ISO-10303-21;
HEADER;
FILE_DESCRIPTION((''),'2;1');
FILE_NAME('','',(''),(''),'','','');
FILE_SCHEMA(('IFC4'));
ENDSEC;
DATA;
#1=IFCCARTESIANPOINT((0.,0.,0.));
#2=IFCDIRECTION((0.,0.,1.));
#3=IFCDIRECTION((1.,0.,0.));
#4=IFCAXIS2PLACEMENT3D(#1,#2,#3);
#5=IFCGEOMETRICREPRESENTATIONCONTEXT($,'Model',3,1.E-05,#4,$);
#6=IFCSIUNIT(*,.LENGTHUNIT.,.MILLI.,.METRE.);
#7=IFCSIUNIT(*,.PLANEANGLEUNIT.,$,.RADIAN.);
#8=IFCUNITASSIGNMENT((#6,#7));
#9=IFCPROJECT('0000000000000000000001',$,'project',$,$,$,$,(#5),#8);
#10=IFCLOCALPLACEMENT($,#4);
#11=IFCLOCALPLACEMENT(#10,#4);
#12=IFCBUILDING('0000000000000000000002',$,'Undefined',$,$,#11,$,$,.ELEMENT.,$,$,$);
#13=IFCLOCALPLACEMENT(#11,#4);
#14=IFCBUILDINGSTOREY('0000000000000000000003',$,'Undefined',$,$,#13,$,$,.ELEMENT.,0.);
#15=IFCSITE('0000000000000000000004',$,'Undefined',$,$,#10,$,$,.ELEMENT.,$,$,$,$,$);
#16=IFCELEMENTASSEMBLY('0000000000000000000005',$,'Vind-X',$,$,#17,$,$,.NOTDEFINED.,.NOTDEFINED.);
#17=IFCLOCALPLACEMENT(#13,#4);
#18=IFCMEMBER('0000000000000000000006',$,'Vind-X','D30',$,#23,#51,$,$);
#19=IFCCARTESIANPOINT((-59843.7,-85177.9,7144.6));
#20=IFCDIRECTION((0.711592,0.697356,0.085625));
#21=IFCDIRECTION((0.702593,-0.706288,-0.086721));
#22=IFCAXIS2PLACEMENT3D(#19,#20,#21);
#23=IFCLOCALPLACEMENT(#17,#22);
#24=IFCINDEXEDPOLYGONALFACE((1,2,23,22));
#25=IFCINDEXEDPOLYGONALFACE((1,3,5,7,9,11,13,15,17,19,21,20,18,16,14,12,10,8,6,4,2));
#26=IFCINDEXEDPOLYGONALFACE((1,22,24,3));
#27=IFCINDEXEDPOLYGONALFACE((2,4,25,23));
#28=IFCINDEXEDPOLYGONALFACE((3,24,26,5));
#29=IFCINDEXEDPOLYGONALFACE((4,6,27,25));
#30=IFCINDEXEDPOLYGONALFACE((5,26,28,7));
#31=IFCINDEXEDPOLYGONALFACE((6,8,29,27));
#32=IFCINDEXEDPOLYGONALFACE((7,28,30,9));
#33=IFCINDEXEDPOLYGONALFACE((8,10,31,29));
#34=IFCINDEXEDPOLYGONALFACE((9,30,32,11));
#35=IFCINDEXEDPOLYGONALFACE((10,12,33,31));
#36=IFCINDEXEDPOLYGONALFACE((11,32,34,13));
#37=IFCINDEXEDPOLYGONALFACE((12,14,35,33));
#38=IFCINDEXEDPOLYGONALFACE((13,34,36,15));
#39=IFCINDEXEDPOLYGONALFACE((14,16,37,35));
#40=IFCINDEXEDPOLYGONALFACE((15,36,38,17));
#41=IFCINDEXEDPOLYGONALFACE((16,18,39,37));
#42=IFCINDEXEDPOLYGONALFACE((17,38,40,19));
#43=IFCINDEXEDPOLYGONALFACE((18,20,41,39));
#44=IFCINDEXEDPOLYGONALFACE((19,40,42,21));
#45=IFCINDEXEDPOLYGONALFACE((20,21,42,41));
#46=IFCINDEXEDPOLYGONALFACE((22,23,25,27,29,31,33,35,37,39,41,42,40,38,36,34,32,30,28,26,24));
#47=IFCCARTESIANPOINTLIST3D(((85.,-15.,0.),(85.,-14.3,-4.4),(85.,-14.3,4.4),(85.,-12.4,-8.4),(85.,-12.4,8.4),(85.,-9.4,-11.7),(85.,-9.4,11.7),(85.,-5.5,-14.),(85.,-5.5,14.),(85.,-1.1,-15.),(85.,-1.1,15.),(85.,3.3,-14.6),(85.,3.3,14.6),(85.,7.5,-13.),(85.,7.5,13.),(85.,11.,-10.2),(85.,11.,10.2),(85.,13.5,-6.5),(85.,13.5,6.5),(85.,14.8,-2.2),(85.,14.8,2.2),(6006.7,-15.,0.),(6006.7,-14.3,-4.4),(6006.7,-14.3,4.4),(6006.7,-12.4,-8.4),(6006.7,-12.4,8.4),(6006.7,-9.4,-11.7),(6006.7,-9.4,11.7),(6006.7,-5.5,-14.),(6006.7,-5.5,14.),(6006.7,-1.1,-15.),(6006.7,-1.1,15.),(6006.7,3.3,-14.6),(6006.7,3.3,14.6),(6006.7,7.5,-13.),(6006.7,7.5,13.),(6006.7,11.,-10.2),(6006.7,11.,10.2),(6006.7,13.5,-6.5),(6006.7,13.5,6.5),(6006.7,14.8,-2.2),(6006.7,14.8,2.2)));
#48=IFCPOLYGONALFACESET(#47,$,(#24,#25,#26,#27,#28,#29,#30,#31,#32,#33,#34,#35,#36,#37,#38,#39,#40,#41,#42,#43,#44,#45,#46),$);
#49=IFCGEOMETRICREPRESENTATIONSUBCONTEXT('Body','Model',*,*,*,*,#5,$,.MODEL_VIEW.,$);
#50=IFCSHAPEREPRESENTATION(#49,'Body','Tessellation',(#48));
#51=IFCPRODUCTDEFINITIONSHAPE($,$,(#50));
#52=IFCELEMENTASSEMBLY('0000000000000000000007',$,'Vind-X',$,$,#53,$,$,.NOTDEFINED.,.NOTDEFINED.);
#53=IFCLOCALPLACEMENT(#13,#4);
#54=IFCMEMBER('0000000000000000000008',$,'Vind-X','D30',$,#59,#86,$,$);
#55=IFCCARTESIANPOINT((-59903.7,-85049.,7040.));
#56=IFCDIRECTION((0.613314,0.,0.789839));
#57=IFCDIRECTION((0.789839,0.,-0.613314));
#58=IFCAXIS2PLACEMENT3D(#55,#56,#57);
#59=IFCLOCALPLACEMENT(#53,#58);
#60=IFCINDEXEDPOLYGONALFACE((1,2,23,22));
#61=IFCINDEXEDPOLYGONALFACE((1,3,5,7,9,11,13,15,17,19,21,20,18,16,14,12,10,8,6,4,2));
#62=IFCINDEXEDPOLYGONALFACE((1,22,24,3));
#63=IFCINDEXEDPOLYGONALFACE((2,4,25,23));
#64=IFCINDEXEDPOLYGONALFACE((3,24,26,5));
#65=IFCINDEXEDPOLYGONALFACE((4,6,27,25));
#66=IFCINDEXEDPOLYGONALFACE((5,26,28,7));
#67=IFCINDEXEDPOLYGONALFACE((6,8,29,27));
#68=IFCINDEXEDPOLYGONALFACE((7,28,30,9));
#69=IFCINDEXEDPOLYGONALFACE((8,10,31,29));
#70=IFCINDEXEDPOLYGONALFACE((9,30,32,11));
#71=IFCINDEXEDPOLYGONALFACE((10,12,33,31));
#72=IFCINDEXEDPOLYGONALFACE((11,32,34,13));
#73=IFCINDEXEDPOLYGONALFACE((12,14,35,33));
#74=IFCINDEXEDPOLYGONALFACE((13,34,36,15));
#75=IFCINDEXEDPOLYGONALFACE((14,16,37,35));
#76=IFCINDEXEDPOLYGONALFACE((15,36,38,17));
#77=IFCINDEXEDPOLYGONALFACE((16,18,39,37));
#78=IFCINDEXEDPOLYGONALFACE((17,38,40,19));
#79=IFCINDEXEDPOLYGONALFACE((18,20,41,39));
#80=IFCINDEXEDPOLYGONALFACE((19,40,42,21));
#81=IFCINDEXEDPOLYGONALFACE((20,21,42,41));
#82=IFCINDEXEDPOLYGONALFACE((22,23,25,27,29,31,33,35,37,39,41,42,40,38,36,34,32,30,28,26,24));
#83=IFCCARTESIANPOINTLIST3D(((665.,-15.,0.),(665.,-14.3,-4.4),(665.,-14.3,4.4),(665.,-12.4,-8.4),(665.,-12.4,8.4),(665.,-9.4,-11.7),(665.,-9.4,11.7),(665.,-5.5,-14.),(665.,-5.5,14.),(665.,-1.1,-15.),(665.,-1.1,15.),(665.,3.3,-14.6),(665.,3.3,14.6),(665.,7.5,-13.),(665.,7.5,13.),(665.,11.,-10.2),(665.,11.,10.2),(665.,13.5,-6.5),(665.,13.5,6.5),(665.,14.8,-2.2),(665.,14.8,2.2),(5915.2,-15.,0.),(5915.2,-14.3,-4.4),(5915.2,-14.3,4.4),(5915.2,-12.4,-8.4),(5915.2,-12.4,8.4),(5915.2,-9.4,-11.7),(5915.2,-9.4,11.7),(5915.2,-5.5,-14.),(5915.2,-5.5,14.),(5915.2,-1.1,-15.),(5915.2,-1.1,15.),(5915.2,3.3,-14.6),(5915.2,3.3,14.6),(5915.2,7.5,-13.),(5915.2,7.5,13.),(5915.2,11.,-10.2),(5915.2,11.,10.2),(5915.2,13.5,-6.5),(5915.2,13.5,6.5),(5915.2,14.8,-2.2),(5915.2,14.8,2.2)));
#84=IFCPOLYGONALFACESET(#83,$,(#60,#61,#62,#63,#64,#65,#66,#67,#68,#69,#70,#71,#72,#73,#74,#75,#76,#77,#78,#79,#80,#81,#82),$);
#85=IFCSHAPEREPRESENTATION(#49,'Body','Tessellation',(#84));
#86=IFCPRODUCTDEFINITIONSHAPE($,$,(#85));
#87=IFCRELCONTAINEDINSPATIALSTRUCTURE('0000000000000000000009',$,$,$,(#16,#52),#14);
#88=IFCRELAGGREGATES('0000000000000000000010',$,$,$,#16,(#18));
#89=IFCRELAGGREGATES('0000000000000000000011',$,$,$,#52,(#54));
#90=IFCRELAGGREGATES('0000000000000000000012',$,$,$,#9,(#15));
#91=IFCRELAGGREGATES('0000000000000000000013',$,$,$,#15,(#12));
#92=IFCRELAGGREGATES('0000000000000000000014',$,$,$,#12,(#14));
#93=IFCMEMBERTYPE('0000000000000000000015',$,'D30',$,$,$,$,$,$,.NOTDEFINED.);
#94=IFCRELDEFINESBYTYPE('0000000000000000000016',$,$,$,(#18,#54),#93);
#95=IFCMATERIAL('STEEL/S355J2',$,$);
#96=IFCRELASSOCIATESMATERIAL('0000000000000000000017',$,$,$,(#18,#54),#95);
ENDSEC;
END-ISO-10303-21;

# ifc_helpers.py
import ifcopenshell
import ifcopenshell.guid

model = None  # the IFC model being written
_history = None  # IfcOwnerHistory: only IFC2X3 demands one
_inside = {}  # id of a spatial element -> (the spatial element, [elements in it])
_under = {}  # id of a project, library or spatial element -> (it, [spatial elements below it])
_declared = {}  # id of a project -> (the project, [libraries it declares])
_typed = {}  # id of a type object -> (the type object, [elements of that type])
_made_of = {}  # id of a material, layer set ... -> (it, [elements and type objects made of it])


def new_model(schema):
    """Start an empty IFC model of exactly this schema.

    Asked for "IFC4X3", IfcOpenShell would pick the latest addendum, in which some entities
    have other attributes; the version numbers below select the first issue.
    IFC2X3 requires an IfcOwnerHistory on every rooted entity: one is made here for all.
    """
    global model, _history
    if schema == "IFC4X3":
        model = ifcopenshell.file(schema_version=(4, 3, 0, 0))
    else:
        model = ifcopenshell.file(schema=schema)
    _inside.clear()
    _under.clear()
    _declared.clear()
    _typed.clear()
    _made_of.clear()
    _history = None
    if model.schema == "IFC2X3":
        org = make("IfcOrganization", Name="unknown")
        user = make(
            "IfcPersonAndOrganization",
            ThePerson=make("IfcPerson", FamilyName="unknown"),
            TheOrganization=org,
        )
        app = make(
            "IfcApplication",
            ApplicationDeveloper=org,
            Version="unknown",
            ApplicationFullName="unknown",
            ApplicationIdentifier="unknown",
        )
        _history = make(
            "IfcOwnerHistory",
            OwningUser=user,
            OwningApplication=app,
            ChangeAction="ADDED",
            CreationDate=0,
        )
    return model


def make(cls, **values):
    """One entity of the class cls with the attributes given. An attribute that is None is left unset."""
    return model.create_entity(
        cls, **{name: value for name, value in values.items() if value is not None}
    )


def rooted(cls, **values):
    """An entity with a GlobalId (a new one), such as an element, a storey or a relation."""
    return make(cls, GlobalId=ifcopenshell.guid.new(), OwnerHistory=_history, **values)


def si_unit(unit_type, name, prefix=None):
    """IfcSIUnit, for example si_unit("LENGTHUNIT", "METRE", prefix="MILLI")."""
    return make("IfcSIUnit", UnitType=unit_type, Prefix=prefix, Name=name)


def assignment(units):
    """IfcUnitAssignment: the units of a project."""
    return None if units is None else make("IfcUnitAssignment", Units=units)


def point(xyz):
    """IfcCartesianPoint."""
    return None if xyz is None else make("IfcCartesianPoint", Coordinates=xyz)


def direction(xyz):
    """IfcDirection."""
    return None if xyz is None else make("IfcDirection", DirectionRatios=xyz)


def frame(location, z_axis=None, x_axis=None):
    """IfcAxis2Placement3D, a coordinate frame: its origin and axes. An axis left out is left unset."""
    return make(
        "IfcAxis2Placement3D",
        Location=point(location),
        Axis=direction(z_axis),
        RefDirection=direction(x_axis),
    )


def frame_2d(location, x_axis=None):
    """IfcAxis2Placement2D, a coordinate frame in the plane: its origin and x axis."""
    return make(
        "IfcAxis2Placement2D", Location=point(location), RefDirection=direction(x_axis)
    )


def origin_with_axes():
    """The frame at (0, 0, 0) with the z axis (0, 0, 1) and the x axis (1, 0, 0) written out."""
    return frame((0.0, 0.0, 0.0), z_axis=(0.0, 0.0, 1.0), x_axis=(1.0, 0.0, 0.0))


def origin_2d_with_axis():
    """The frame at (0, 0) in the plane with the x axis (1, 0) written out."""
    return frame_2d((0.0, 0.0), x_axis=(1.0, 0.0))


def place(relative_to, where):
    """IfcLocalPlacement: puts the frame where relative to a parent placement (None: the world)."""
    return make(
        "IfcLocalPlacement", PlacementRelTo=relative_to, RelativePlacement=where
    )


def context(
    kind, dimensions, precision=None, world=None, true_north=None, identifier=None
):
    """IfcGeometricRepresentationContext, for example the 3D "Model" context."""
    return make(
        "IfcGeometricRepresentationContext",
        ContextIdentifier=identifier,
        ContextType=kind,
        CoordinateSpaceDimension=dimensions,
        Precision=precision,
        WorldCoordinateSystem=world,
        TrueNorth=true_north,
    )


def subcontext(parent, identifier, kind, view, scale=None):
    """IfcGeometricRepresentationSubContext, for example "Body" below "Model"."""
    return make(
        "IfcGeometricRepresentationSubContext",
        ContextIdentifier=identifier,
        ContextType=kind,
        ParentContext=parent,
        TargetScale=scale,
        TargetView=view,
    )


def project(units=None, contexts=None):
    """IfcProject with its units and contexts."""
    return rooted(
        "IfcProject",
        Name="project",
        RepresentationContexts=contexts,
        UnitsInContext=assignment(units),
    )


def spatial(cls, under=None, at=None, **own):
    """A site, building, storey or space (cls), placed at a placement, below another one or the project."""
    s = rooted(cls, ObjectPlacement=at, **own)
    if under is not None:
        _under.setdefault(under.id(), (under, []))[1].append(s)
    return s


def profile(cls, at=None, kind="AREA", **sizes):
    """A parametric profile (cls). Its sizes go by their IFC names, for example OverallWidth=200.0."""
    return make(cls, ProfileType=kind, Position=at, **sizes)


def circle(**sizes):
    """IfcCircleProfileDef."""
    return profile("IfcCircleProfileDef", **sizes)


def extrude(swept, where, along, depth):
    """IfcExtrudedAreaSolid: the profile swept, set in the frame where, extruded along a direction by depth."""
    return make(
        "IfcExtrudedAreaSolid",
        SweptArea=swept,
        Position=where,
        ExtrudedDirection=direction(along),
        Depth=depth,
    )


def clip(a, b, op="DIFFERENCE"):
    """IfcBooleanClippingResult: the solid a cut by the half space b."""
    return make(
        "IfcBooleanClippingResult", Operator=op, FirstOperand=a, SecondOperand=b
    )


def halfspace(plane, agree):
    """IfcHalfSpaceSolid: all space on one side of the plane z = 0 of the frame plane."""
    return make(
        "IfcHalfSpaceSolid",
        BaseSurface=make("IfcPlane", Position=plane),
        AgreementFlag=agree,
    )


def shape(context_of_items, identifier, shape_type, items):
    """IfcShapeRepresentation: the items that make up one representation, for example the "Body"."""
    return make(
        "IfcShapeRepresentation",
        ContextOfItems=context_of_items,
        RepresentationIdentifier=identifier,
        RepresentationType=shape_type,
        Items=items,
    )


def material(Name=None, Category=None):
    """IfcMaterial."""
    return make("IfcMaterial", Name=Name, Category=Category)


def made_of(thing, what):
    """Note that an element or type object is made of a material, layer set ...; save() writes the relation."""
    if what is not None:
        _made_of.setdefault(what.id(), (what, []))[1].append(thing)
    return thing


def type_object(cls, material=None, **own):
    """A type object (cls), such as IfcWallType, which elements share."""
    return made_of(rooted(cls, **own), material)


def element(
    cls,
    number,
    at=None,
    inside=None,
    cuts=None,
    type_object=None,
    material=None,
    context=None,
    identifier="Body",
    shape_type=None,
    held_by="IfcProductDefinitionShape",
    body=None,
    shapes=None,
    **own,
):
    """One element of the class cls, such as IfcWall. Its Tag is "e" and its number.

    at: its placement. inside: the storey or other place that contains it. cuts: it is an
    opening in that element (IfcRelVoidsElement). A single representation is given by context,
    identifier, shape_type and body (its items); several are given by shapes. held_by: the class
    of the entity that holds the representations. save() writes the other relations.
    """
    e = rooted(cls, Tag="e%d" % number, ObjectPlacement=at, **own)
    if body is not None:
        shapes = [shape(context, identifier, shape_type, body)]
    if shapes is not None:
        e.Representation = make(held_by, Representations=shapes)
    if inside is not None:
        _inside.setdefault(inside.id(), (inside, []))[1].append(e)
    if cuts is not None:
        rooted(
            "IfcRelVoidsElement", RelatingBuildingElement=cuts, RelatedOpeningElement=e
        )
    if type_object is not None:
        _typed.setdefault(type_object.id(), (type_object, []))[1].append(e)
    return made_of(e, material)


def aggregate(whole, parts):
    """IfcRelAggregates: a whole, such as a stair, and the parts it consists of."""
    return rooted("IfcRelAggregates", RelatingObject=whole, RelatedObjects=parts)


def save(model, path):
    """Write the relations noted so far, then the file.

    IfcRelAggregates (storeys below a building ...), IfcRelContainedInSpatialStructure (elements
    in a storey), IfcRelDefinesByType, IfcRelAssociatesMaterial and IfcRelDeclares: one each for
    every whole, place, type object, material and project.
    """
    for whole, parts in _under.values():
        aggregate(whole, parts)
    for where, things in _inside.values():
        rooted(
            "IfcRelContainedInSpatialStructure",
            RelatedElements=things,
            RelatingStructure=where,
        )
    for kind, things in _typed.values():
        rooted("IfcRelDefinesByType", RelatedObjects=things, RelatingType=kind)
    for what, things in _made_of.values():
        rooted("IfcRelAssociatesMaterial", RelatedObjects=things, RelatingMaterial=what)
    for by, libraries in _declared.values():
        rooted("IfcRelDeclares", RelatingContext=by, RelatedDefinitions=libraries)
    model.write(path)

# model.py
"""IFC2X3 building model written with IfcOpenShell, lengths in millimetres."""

from ifc_helpers import new_model, si_unit, frame, origin_with_axes, origin_2d_with_axis, place, context, subcontext, project, spatial, circle, extrude, clip, halfspace, material, type_object, element, aggregate, save


model = new_model("IFC2X3")

# Units and contexts
model_context = context("Model", 3, precision=1e-05, world=origin_with_axes())
body_context = subcontext(model_context, "Body", "Model", "MODEL_VIEW")
ifc_project = project(units=[si_unit("LENGTHUNIT", "METRE", prefix="MILLI"), si_unit("PLANEANGLEUNIT", "RADIAN")], contexts=[model_context])

# Site, building, storey
site_placement = place(None, origin_with_axes())
site = spatial("IfcSite", under=ifc_project, at=site_placement, Name="Undefined", CompositionType="ELEMENT")
building_placement = place(site_placement, origin_with_axes())
building = spatial("IfcBuilding", under=site, at=building_placement, Name="Undefined", CompositionType="ELEMENT")
storey_placement = place(building_placement, origin_with_axes())
storey = spatial("IfcBuildingStorey", under=building, at=storey_placement, Name="Undefined", CompositionType="ELEMENT", Elevation=0.0)

# Element assembly, member
assembly_1_placement = place(storey_placement, origin_with_axes())
assembly_1 = element("IfcElementAssembly", 1, at=assembly_1_placement, inside=storey, Name="Vind-X", AssemblyPlace="NOTDEFINED", PredefinedType="NOTDEFINED")
ifc_material_1 = material(Name="STEEL/S355J2")
member_type = type_object("IfcMemberType", Name="D30", PredefinedType="NOTDEFINED")
member_1_placement = place(assembly_1_placement, frame((-59843.7, -85177.9, 7144.6), z_axis=(0.711592, 0.697356, 0.085625), x_axis=(0.702593, -0.706288, -0.086721)))
member_1 = element("IfcMember", 2, at=member_1_placement, type_object=member_type, material=ifc_material_1, Name="Vind-X", Description="D30", context=body_context, shape_type="Clipping", body=[
    clip(clip(extrude(circle(Radius=15.0, at=origin_2d_with_axis()), frame((6671.7, 0.0, 0.0), z_axis=(-1.0, 0.0, 0.0), x_axis=(0.0, -1.0, 0.0)), (0.0, 0.0, 1.0), 6671.7), halfspace(frame((6006.7, -6.0, 10.2), z_axis=(1.0, 0.0, 0.0), x_axis=(0.0, 1.0, 0.0)), False)), halfspace(frame((85.0, -6.0, 16.0), z_axis=(1.0, 0.0, 0.0), x_axis=(0.0, 1.0, 0.0)), True)),
])

# Element assembly, member
assembly_2_placement = place(storey_placement, origin_with_axes())
assembly_2 = element("IfcElementAssembly", 3, at=assembly_2_placement, inside=storey, Name="Vind-X", AssemblyPlace="NOTDEFINED", PredefinedType="NOTDEFINED")
member_2_placement = place(assembly_2_placement, frame((-59903.7, -85049.0, 7040.0), z_axis=(0.613314, 0.0, 0.789839), x_axis=(0.789839, 0.0, -0.613314)))
member_2 = element("IfcMember", 4, at=member_2_placement, type_object=member_type, material=ifc_material_1, Name="Vind-X", Description="D30", context=body_context, shape_type="Clipping", body=[
    clip(clip(extrude(circle(Radius=15.0, at=origin_2d_with_axis()), frame((6000.2, 0.0, 0.0), z_axis=(-1.0, 0.0, 0.0), x_axis=(0.0, -1.0, 0.0)), (0.0, 0.0, 1.0), 6000.2), halfspace(frame((5915.2, 6.0, 16.0), z_axis=(-1.0, 0.0, 0.0), x_axis=(0.0, -1.0, 0.0)), True)), halfspace(frame((665.0, 6.0, 10.2), z_axis=(-1.0, 0.0, 0.0), x_axis=(0.0, -1.0, 0.0)), False)),
])

aggregate(assembly_1, [member_1])
aggregate(assembly_2, [member_2])

save(model, "model.ifc")
